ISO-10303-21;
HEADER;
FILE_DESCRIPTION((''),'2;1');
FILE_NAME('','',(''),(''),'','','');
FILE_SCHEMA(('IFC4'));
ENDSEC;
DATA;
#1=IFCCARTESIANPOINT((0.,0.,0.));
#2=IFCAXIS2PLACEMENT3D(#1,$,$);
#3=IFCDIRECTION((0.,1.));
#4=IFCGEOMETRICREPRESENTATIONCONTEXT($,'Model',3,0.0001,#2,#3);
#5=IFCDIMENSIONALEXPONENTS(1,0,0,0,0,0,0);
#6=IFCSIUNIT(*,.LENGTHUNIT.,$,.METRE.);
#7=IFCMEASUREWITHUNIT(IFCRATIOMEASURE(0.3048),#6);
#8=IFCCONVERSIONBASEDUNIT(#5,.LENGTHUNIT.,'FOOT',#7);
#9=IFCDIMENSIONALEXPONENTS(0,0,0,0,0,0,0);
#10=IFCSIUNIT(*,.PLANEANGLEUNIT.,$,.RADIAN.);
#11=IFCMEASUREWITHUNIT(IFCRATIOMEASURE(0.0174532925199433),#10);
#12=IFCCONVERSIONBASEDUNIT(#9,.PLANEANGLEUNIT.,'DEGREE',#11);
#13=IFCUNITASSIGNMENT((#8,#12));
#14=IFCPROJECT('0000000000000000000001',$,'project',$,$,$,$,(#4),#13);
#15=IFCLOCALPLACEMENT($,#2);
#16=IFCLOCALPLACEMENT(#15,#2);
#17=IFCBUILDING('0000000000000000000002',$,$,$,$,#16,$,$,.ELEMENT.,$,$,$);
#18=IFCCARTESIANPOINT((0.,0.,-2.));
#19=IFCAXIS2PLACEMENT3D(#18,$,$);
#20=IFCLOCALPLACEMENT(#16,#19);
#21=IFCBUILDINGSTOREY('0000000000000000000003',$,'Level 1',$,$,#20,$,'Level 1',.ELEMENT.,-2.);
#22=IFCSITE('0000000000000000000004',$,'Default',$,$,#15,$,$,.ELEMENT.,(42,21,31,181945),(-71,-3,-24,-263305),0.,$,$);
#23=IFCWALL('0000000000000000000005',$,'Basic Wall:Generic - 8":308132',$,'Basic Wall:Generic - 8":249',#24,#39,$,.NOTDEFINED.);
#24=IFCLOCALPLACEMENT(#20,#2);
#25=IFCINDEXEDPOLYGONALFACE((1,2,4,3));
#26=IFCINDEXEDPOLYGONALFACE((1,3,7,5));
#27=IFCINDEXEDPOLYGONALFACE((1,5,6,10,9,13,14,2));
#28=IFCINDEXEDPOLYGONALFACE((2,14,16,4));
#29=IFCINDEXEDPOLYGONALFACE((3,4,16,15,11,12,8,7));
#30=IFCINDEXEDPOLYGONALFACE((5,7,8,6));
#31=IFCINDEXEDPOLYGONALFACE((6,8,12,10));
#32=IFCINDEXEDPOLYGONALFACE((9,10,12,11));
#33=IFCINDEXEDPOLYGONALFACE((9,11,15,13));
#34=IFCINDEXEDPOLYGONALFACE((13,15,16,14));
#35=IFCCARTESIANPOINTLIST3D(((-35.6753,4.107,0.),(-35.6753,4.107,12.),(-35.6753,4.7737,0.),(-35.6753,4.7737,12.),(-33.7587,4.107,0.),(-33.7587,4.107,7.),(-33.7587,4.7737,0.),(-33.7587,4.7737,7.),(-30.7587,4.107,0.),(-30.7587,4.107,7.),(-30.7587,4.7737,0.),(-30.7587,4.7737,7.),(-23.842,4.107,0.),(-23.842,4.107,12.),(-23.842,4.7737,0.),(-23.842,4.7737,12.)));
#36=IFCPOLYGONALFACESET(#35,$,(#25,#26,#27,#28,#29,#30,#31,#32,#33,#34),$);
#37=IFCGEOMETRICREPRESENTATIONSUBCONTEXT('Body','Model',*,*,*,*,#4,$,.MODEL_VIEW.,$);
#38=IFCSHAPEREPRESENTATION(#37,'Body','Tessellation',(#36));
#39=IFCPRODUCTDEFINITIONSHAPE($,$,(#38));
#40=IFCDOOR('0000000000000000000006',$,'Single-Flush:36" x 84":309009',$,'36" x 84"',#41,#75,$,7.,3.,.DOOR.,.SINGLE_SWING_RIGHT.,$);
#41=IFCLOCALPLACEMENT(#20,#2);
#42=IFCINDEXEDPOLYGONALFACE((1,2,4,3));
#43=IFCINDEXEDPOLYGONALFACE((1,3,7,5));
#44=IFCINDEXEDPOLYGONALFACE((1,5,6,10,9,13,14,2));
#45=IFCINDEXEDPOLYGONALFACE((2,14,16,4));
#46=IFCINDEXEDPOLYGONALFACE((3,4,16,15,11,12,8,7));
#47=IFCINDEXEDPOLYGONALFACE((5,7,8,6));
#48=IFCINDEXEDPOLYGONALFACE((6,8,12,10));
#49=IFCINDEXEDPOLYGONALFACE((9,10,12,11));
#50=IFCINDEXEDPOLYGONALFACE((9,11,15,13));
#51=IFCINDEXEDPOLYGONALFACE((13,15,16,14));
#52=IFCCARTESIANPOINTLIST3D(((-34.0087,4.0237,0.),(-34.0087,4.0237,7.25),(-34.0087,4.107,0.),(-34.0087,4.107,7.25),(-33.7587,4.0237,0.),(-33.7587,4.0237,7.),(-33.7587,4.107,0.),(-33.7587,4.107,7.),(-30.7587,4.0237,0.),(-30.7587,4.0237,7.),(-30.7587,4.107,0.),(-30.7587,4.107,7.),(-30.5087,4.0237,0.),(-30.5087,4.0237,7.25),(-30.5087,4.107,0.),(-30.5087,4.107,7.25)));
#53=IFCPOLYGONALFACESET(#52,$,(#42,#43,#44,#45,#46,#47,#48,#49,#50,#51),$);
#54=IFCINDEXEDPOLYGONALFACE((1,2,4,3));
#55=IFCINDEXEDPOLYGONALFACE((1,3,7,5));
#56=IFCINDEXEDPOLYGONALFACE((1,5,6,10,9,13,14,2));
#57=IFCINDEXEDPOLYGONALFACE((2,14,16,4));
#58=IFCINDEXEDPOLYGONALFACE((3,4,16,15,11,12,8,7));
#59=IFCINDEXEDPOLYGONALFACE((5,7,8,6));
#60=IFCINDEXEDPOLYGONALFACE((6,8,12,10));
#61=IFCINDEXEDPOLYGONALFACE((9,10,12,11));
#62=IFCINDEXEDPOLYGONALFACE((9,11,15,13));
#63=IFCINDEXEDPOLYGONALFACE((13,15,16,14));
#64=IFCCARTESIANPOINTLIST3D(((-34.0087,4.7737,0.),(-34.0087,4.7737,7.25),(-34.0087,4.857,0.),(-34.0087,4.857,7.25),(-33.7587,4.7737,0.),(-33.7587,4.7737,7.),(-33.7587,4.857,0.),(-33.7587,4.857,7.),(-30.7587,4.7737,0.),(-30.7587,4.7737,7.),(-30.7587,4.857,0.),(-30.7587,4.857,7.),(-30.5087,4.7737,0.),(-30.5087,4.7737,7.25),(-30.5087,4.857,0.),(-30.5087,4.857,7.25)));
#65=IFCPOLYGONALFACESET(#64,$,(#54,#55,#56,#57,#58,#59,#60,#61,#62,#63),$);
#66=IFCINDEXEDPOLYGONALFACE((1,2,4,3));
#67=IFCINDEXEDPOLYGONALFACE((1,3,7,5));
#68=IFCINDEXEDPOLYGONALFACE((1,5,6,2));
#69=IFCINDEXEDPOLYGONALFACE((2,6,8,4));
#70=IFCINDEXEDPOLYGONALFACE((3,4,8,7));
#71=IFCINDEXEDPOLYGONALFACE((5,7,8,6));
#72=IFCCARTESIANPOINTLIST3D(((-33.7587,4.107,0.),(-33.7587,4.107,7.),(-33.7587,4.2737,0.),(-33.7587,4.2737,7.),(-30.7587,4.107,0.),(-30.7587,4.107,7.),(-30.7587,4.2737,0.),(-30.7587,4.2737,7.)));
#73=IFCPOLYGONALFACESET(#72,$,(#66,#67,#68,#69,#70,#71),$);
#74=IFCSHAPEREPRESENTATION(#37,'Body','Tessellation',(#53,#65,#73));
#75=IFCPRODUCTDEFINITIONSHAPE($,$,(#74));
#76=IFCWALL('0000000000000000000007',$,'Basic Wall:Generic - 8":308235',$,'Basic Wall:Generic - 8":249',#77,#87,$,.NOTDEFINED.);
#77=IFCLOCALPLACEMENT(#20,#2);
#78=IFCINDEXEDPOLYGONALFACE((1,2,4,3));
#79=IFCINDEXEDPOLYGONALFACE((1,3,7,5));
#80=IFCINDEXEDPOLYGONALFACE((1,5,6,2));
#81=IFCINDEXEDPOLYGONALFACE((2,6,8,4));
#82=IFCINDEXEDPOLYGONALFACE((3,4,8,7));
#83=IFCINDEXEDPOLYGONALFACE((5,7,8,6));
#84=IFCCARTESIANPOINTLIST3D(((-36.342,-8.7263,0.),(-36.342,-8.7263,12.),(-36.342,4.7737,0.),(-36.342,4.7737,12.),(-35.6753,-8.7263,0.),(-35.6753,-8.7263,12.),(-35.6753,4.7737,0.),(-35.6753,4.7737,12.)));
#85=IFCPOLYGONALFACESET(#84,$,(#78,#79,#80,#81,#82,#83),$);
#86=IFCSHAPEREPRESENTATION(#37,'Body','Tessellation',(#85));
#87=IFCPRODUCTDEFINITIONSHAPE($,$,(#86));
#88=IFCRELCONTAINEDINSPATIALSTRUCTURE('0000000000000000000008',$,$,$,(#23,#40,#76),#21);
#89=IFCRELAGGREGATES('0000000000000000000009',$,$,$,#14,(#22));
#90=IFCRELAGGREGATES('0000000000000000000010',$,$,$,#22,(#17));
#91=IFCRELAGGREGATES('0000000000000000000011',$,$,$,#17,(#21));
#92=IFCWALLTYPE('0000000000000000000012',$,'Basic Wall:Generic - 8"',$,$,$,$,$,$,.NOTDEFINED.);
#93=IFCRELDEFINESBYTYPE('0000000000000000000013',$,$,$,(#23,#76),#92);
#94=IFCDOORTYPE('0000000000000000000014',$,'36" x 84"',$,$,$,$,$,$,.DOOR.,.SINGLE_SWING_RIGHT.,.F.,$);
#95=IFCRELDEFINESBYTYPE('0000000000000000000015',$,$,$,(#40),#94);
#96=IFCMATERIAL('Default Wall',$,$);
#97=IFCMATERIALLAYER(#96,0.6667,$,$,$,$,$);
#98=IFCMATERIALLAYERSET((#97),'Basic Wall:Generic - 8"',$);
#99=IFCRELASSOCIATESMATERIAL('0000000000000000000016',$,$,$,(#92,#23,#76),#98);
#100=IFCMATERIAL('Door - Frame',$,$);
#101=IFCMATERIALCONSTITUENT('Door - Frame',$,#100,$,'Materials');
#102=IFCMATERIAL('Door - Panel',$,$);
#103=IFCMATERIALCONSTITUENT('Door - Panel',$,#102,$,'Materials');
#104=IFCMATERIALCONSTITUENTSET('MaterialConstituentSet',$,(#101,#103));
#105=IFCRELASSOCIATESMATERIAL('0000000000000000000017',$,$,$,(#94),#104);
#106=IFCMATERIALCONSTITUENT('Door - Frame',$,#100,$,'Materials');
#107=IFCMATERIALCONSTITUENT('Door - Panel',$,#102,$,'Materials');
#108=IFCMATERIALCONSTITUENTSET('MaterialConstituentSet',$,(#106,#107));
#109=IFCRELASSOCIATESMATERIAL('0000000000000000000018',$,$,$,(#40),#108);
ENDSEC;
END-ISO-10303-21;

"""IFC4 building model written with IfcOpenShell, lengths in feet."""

from ifc_helpers import new_model, entity, si_unit, converted_unit, direction, frame, frame_2d, origin, place, context, subcontext, project, spatial, polyline, rectangle, outline, extrude, source, transform, mapped, material, layer, layer_set, layer_usage, constituent, constituent_set, type_object, type_shapes, element, fill, save


model = new_model("IFC4")

# Units and contexts
model_context = context("Model", 3, precision=0.0001, world=origin(), true_north=direction((0.0, 1.0)))
body_context = subcontext(model_context, "Body", "Model", "MODEL_VIEW")
ifc_project = project(units=[converted_unit("LENGTHUNIT", "FOOT", entity("IfcRatioMeasure", 0.3048), si_unit("LENGTHUNIT", "METRE"), dimensions=[1, 0, 0, 0, 0, 0, 0]), converted_unit("PLANEANGLEUNIT", "DEGREE", entity("IfcRatioMeasure", 0.0174532925199433), si_unit("PLANEANGLEUNIT", "RADIAN"), dimensions=[0, 0, 0, 0, 0, 0, 0])], contexts=[model_context])

# Site, building, storey
site_placement = place(None, origin())
site = spatial("IfcSite", under=ifc_project, at=site_placement, Name="Default", CompositionType="ELEMENT", RefLatitude=(42, 21, 31, 181945), RefLongitude=(-71, -3, -24, -263305), RefElevation=0.0)
building_placement = place(site_placement, origin())
building = spatial("IfcBuilding", under=site, at=building_placement, CompositionType="ELEMENT")
storey_placement = place(building_placement, frame((0.0, 0.0, -2.0)))
storey = spatial("IfcBuildingStorey", under=building, at=storey_placement, Name="Level 1", LongName="Level 1", CompositionType="ELEMENT", Elevation=-2.0)

# Shared definitions
ifc_material_1 = material(Name="Default Wall")
ifc_layer = layer(ifc_material_1, 0.6667)
ifc_layer_set = layer_set([ifc_layer], Name="Basic Wall:Generic - 8\"")
wall_type = type_object("IfcWallType", Name="Basic Wall:Generic - 8\"", PredefinedType="NOTDEFINED", material=ifc_layer_set)

# Wall, opening, door
ifc_layer_usage_1 = layer_usage(ifc_layer_set, "AXIS2", "NEGATIVE", 0.3333)
wall_1_placement = place(storey_placement, frame((-35.6753, 4.4404, 0.0)))
wall_1 = element("IfcWall", 1, at=wall_1_placement, inside=storey, type_object=wall_type, material=ifc_layer_usage_1, Name="Basic Wall:Generic - 8\":308132", ObjectType="Basic Wall:Generic - 8\":249", PredefinedType="NOTDEFINED", context=body_context, shape_type="SweptSolid", body=[
    extrude(rectangle(XDim=11.8333, YDim=0.6667, at=frame_2d((5.9167, 0.0), x_axis=(-1.0, 0.0))), origin(), (0.0, 0.0, 1.0), 12.0),
])
opening_1_placement = place(wall_1_placement, frame((4.9167, 0.3333, 0.0)))
opening_1 = element("IfcOpeningElement", 2, at=opening_1_placement, cuts=wall_1, ObjectType="Opening", PredefinedType="OPENING", context=body_context, shape_type="SweptSolid", body=[
    extrude(rectangle(XDim=3.0, YDim=7.0, at=frame_2d((3.5, 1.5), x_axis=(0.0, 1.0))), frame((0.0, 0.0, 0.0), z_axis=(0.0, -1.0, 0.0), x_axis=(0.0, 0.0, 1.0)), (0.0, 0.0, 1.0), 0.6667),
])
ifc_material_2 = material(Name="Door - Frame")
ifc_constituent_1 = constituent(ifc_material_2, Name="Door - Frame", Category="Materials")
ifc_material_3 = material(Name="Door - Panel")
ifc_constituent_2 = constituent(ifc_material_3, Name="Door - Panel", Category="Materials")
ifc_constituent_set_1 = constituent_set(constituents=[ifc_constituent_1, ifc_constituent_2], Name="MaterialConstituentSet")
ifc_constituent_3 = constituent(ifc_material_2, Name="Door - Frame", Category="Materials")
ifc_constituent_4 = constituent(ifc_material_3, Name="Door - Panel", Category="Materials")
ifc_constituent_set_2 = constituent_set(constituents=[ifc_constituent_3, ifc_constituent_4], Name="MaterialConstituentSet")
door_type = type_object("IfcDoorType", Name="36\" x 84\"", OperationType="SINGLE_SWING_RIGHT", ParameterTakesPrecedence=False, PredefinedType="DOOR", material=ifc_constituent_set_2)
shared_shape_1 = source(origin(), body_context, "Body", "SweptSolid", [
    extrude(outline(polyline([(-1.75, -3.6875), (1.75, -3.6875), (1.75, 3.5625), (1.5, 3.5625), (1.5, -3.4375), (-1.5, -3.4375), (-1.5, 3.5625), (-1.75, 3.5625), (-1.75, -3.6875)])), frame((1.5, 0.6667, 3.5625), z_axis=(0.0, 1.0, 0.0), x_axis=(1.0, 0.0, 0.0)), (0.0, 0.0, 1.0), 0.0833),
    extrude(outline(polyline([(-3.6875, -1.75), (3.5625, -1.75), (3.5625, -1.5), (-3.4375, -1.5), (-3.4375, 1.5), (3.5625, 1.5), (3.5625, 1.75), (-3.6875, 1.75), (-3.6875, -1.75)])), frame((1.5, -0.0833, 3.5625), z_axis=(0.0, 1.0, 0.0), x_axis=(0.0, 0.0, -1.0)), (0.0, 0.0, 1.0), 0.0833),
    extrude(rectangle(XDim=0.1667, YDim=3.0, at=frame_2d((0.0, 0.0), x_axis=(1.0, 0.0))), frame((1.5, 0.5833, 0.0), z_axis=(0.0, 0.0, 1.0), x_axis=(0.0, 1.0, 0.0)), (0.0, 0.0, 1.0), 7.0),
])
type_shapes(door_type, [shared_shape_1])
door_placement = place(opening_1_placement, frame((0.0, 0.0, 0.0), z_axis=(0.0, 0.0, 1.0), x_axis=(-1.0, 0.0, 0.0)))
door = element("IfcDoor", 3, at=door_placement, inside=storey, type_object=door_type, material=ifc_constituent_set_1, Name="Single-Flush:36\" x 84\":309009", ObjectType="36\" x 84\"", OperationType="SINGLE_SWING_RIGHT", OverallHeight=7.0, OverallWidth=3.0, PredefinedType="DOOR", context=body_context, shape_type="MappedRepresentation", body=[
    mapped(shared_shape_1, transform((0.0, 0.0, 0.0), scale=1.0)),
])
fill(opening_1, door)

# Wall
ifc_layer_usage_2 = layer_usage(ifc_layer_set, "AXIS2", "NEGATIVE", 0.3333)
wall_2_placement = place(storey_placement, frame((-36.0087, 4.7737, 0.0), z_axis=(0.0, 0.0, 1.0), x_axis=(0.0, -1.0, 0.0)))
element("IfcWall", 4, at=wall_2_placement, inside=storey, type_object=wall_type, material=ifc_layer_usage_2, Name="Basic Wall:Generic - 8\":308235", ObjectType="Basic Wall:Generic - 8\":249", PredefinedType="NOTDEFINED", context=body_context, shape_type="SweptSolid", body=[
    extrude(rectangle(XDim=13.5, YDim=0.6667, at=frame_2d((6.75, 0.0), x_axis=(-1.0, 0.0))), origin(), (0.0, 0.0, 1.0), 12.0),
])

save(model, "model.ifc")
